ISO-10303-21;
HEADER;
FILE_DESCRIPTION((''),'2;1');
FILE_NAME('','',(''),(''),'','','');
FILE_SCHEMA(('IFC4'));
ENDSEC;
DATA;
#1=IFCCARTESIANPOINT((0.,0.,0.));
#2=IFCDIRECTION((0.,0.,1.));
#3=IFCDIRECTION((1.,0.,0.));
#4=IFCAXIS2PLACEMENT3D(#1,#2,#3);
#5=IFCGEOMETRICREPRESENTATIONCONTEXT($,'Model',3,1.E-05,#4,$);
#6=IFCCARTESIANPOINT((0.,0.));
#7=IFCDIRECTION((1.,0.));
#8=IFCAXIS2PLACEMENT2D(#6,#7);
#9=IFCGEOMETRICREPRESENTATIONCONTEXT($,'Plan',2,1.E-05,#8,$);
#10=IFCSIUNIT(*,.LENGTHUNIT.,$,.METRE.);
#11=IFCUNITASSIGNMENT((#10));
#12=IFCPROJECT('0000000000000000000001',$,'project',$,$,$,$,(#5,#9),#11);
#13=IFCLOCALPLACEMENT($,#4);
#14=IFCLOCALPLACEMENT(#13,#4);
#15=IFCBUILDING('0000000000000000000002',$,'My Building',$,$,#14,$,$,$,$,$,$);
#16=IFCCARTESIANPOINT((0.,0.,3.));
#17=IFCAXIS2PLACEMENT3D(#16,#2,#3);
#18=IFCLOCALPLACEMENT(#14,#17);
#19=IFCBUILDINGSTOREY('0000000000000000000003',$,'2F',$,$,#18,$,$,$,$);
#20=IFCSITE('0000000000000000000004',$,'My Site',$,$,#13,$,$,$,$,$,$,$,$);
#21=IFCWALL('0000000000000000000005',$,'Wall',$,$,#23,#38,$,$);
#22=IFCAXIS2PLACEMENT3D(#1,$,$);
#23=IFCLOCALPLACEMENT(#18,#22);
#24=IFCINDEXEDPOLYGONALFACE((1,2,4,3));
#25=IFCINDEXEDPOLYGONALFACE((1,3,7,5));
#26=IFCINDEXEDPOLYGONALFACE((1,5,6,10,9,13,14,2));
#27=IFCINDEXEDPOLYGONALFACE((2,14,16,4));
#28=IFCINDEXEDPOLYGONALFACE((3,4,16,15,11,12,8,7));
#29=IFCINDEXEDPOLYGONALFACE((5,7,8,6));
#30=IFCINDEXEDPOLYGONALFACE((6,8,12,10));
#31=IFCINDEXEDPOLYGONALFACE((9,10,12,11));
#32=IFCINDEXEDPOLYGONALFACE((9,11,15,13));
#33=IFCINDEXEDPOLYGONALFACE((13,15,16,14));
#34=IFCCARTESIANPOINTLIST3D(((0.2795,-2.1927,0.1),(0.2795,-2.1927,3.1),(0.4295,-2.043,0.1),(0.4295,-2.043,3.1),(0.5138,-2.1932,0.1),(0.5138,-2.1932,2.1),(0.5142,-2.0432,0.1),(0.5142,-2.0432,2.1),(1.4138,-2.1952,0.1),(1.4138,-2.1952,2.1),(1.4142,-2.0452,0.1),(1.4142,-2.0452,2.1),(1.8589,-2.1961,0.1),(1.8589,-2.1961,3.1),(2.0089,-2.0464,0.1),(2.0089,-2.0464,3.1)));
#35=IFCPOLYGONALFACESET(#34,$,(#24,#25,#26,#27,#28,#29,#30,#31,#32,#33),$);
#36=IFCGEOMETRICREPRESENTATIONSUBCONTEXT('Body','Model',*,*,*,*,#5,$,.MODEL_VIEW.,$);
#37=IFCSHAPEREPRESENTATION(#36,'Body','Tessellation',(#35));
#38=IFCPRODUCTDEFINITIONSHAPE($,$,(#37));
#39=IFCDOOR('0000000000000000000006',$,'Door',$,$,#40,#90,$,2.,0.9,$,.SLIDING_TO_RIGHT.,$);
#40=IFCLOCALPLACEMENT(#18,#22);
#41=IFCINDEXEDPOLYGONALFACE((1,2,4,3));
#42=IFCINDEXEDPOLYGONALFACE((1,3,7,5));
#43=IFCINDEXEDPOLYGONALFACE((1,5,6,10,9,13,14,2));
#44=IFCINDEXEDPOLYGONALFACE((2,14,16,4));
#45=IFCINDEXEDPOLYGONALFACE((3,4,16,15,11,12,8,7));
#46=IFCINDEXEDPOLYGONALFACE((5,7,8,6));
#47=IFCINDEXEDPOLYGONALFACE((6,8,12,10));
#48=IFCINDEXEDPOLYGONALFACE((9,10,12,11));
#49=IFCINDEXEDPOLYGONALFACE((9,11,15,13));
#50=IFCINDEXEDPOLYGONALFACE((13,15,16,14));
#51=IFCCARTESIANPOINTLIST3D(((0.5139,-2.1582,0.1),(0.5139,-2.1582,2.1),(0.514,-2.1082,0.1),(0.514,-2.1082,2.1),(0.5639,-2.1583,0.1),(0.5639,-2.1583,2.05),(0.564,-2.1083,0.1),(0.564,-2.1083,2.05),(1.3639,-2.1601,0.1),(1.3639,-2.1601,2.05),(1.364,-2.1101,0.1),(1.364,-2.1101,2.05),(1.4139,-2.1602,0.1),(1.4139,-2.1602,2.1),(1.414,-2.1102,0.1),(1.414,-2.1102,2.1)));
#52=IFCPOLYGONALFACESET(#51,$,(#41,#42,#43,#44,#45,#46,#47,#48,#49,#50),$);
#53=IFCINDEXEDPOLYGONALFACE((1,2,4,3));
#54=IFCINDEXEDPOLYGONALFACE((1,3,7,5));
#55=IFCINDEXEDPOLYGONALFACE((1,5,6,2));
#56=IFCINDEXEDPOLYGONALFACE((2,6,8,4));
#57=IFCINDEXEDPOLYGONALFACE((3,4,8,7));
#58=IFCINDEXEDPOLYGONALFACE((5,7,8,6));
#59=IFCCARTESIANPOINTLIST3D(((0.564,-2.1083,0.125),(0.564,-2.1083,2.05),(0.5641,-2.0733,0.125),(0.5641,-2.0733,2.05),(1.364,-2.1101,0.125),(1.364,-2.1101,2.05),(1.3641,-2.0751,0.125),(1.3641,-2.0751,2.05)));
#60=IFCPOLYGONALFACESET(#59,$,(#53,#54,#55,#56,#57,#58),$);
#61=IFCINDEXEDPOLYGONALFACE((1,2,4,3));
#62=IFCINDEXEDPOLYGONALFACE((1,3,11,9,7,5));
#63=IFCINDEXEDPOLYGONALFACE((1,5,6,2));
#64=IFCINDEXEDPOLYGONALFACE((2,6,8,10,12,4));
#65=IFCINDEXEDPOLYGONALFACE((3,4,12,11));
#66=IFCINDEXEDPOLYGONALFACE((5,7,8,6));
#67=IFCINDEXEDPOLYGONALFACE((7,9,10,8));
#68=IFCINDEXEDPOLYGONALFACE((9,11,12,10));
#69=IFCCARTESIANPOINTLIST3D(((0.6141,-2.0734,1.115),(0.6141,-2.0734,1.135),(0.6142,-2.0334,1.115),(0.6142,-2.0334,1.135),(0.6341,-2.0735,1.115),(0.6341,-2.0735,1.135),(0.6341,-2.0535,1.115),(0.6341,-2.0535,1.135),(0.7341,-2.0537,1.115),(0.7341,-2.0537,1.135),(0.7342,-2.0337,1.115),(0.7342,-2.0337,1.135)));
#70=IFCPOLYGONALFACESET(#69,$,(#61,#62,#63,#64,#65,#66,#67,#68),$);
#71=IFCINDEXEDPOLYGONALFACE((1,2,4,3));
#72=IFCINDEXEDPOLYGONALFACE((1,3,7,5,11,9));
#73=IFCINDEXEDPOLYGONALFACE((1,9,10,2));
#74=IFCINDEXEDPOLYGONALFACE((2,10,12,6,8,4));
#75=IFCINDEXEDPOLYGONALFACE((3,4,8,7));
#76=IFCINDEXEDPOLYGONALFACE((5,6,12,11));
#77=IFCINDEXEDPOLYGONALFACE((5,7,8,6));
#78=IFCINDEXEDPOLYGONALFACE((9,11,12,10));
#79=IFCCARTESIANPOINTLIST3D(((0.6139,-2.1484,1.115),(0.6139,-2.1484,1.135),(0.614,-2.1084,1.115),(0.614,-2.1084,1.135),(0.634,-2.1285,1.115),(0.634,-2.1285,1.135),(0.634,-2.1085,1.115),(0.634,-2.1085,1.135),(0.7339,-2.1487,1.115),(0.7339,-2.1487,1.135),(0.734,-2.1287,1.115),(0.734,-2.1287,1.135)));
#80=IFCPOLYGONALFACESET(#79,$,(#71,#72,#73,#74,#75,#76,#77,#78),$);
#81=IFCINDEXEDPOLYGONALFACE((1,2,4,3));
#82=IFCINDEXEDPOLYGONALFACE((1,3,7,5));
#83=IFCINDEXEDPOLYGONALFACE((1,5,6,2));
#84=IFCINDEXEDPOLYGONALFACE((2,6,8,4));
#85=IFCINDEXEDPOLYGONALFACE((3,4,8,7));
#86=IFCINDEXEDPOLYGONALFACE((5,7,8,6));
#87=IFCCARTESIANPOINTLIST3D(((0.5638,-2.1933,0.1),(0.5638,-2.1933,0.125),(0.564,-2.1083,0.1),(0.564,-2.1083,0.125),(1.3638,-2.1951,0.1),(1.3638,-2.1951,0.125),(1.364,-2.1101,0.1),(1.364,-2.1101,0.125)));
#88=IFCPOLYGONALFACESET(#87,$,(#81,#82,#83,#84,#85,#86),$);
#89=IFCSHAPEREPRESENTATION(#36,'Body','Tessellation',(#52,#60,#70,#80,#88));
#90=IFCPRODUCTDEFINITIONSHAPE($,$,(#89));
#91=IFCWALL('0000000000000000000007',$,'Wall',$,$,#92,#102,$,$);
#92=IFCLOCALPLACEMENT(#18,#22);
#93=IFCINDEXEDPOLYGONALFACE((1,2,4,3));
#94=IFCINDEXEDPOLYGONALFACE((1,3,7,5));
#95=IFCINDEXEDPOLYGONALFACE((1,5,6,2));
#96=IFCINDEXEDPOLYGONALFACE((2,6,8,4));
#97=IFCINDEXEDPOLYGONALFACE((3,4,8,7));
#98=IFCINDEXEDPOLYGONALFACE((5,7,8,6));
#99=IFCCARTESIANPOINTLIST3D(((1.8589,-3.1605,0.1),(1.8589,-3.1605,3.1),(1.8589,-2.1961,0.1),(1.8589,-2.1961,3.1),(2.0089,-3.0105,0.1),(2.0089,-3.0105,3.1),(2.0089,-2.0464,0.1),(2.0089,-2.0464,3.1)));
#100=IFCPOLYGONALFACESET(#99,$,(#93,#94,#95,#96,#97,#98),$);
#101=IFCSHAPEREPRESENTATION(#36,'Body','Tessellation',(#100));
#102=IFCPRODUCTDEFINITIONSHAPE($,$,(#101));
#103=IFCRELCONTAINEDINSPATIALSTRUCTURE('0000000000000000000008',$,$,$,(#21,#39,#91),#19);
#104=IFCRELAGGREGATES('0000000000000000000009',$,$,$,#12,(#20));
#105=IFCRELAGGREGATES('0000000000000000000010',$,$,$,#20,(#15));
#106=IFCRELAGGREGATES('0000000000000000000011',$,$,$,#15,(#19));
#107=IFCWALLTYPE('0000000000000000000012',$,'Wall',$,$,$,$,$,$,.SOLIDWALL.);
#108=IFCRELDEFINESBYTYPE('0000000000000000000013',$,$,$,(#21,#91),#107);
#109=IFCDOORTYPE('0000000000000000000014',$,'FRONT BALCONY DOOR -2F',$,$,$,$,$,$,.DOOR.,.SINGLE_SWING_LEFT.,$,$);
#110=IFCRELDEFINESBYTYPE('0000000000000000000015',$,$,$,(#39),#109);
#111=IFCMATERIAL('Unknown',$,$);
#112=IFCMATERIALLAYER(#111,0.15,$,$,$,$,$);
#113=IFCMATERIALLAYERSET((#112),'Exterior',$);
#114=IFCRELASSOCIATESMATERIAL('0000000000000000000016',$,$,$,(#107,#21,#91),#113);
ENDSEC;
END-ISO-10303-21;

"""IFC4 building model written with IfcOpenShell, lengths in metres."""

from ifc_helpers import new_model, entity, si_unit, frame, origin_with_axes, origin_2d_with_axis, place, context, subcontext, project, spatial, line, indexed_curve, outline, extrude, shape, source, transform, mapped, material, layer, layer_set, layer_usage, type_object, type_shapes, element, fill, save


model = new_model("IFC4")

# Units and contexts
model_context = context("Model", 3, precision=1e-05, world=origin_with_axes())
plan_context = context("Plan", 2, precision=1e-05, world=origin_2d_with_axis())
body_context_1 = subcontext(model_context, "Body", "Model", "MODEL_VIEW")
body_context_2 = subcontext(plan_context, "Body", "Plan", "PLAN_VIEW")
ifc_project = project(units=[si_unit("LENGTHUNIT", "METRE")], contexts=[model_context, plan_context])

# Site, building, storey
site_placement = place(None, origin_with_axes())
site = spatial("IfcSite", under=ifc_project, at=site_placement, Name="My Site")
building_placement = place(site_placement, origin_with_axes())
building = spatial("IfcBuilding", under=site, at=building_placement, Name="My Building")
storey_placement = place(building_placement, frame((0.0, 0.0, 3.0), z_axis=(0.0, 0.0, 1.0), x_axis=(1.0, 0.0, 0.0)))
storey = spatial("IfcBuildingStorey", under=building, at=storey_placement, Name="2F")

# Shared definitions
ifc_material = material(Name="Unknown")

# Shared definitions
ifc_layer_1 = layer(ifc_material, 0.15)
ifc_layer_set_1 = layer_set([ifc_layer_1], Name="Exterior")
wall_type_1 = type_object("IfcWallType", Name="Wall", PredefinedType="SOLIDWALL", material=ifc_layer_set_1)

# Wall, opening, door
ifc_layer_usage_1 = layer_usage(ifc_layer_set_1, "AXIS2", "POSITIVE", 0.0)
wall_1_placement = place(storey_placement, frame((0.2795, -2.1927, 0.1), z_axis=(0.0, 0.0, 1.0), x_axis=(0.999998, -0.002147, 0.0)))
wall_1 = element("IfcWall", 1, at=wall_1_placement, inside=storey, type_object=wall_type_1, material=ifc_layer_usage_1, Name="Wall", context=body_context_1, shape_type="SweptSolid", body=[
    extrude(outline(indexed_curve([(0.0, 0.0), (0.1497, 0.15), (1.729, 0.15), (1.5793, 0.0)], segments=[line(1, 2, 3, 4, 1)])), origin_with_axes(), (0.0, 0.0, 1.0), 3.0),
])
shared_shape_1 = source(origin_with_axes(), body_context_1, "Body", "SweptSolid", [
    extrude(outline(indexed_curve([(0.0, 0.0), (0.9, 0.0), (0.9, 2.0), (0.0, 2.0)], segments=[line(1, 2, 3, 4, 1)])), frame((0.0, -0.6, 0.0), z_axis=(0.0, -1.0, 0.0), x_axis=(1.0, 0.0, 0.0)), (0.0, 0.0, -1.0), 1.2),
])
opening_1_placement = place(wall_1_placement, frame((1.1343, 0.085, 0.0), z_axis=(0.0, 0.0, 1.0), x_axis=(-1.0, 0.0, 0.0)))
opening_1 = element("IfcOpeningElement", 2, at=opening_1_placement, cuts=wall_1, PredefinedType="OPENING", context=body_context_1, shape_type="MappedRepresentation", body=[
    mapped(shared_shape_1, transform((0.0, 0.0, 0.0), x_axis=(1.0, 0.0, 0.0), y_axis=(0.0, 1.0, 0.0), z_axis=(0.0, 0.0, 1.0), scale=1.0)),
])
door_type_1 = type_object("IfcDoorType", Name="FRONT BALCONY DOOR -2F", OperationType="SINGLE_SWING_LEFT", PredefinedType="DOOR")
shared_shape_2 = source(origin_with_axes(), body_context_1, "Body", "SweptSolid", [
    extrude(outline(indexed_curve([(0.0, 0.0), (0.0, 2.0), (0.9, 2.0), (0.9, 0.0), (0.85, 0.0), (0.85, 1.95), (0.05, 1.95), (0.05, 0.0)], segments=[line(1, 2, 3, 4, 5, 6, 7, 8, 1)])), frame((0.0, 0.0, 0.0), z_axis=(0.0, -1.0, 0.0), x_axis=(1.0, 0.0, 0.0)), (0.0, 0.0, -1.0), 0.05),
    extrude(outline(indexed_curve([(0.0, 0.0), (0.8, 0.0), (0.8, 0.035), (0.0, 0.035)], segments=[line(1, 2, 3, 4, 1)])), frame((0.05, -0.035, 0.025), z_axis=(0.0, 0.0, 1.0), x_axis=(1.0, 0.0, 0.0)), (0.0, 0.0, 1.0), 1.925),
    extrude(outline(indexed_curve([(0.0, 0.0), (0.0, -0.04), (-0.12, -0.04), (-0.12, -0.02), (-0.02, -0.02), (-0.02, 0.0)], segments=[line(1, 2, 3, 4, 5, 6, 1)])), frame((0.8, -0.035, 1.015), z_axis=(0.0, 0.0, 1.0), x_axis=(1.0, 0.0, 0.0)), (0.0, 0.0, 1.0), 0.02),
    extrude(outline(indexed_curve([(0.0, 0.0), (0.0, 0.04), (-0.12, 0.04), (-0.12, 0.02), (-0.02, 0.02), (-0.02, 0.0)], segments=[line(1, 2, 3, 4, 5, 6, 1)])), frame((0.8, 0.0, 1.015), z_axis=(0.0, 0.0, 1.0), x_axis=(1.0, 0.0, 0.0)), (0.0, 0.0, 1.0), 0.02),
    extrude(outline(indexed_curve([(0.0, 0.0), (0.8, 0.0), (0.8, 0.085), (0.0, 0.085)], segments=[line(1, 2, 3, 4, 1)])), frame((0.05, 0.0, 0.0), z_axis=(0.0, 0.0, 1.0), x_axis=(1.0, 0.0, 0.0)), (0.0, 0.0, 1.0), 0.025),
])
shared_shape_3 = source(origin_with_axes(), body_context_2, "Body", "Curve2D", [
    entity("IfcIndexedPolyCurve", entity("IfcCartesianPointList2D", [[0.0, 0.0], [0.05, 0.0], [0.05, 0.05], [0.0, 0.05]]), [entity("IfcLineIndex", [1, 2, 3, 4, 1])]),
    entity("IfcIndexedPolyCurve", entity("IfcCartesianPointList2D", [[0.9, 0.0], [0.85, 0.0], [0.85, 0.05], [0.9, 0.05]]), [entity("IfcLineIndex", [1, 2, 3, 4, 1])]),
    entity("IfcIndexedPolyCurve", entity("IfcCartesianPointList2D", [[-0.35, -0.035], [0.45, -0.035], [0.45, 0.0], [-0.35, 0.0]]), [entity("IfcLineIndex", [1, 2, 3, 4, 1])]),
])
type_shapes(door_type_1, [shared_shape_2, shared_shape_3])
door_1_placement = place(opening_1_placement, frame((0.0, 0.0, 0.0), z_axis=(0.0, 0.0, 1.0), x_axis=(1.0, 0.0, 0.0)))
door_1 = element("IfcDoor", 3, at=door_1_placement, inside=storey, type_object=door_type_1, Name="Door", OperationType="SLIDING_TO_RIGHT", OverallHeight=2.0, OverallWidth=0.9, shapes=[
    shape(body_context_1, "Body", "MappedRepresentation", [mapped(shared_shape_2, transform((0.0, 0.0, 0.0), x_axis=(1.0, 0.0, 0.0), y_axis=(0.0, 1.0, 0.0), z_axis=(0.0, 0.0, 1.0), scale=1.0))]),
    shape(body_context_2, "Body", "MappedRepresentation", [mapped(shared_shape_3, transform((0.0, 0.0, 0.0), x_axis=(1.0, 0.0, 0.0), y_axis=(0.0, 1.0, 0.0), z_axis=(0.0, 0.0, 1.0), scale=1.0))]),
])
fill(opening_1, door_1)

# Wall
ifc_layer_usage_2 = layer_usage(ifc_layer_set_1, "AXIS2", "POSITIVE", 0.0)
wall_2_placement = place(storey_placement, frame((1.8589, -2.1961, 0.1), z_axis=(0.0, 0.0, 1.0), x_axis=(0.0, -1.0, 0.0)))
element("IfcWall", 4, at=wall_2_placement, inside=storey, type_object=wall_type_1, material=ifc_layer_usage_2, Name="Wall", context=body_context_1, shape_type="SweptSolid", body=[
    extrude(outline(indexed_curve([(0.0, 0.0), (-0.1497, 0.15), (0.8144, 0.15), (0.9644, 0.0)], segments=[line(1, 2, 3, 4, 1)])), origin_with_axes(), (0.0, 0.0, 1.0), 3.0),
])

save(model, "model.ifc")
